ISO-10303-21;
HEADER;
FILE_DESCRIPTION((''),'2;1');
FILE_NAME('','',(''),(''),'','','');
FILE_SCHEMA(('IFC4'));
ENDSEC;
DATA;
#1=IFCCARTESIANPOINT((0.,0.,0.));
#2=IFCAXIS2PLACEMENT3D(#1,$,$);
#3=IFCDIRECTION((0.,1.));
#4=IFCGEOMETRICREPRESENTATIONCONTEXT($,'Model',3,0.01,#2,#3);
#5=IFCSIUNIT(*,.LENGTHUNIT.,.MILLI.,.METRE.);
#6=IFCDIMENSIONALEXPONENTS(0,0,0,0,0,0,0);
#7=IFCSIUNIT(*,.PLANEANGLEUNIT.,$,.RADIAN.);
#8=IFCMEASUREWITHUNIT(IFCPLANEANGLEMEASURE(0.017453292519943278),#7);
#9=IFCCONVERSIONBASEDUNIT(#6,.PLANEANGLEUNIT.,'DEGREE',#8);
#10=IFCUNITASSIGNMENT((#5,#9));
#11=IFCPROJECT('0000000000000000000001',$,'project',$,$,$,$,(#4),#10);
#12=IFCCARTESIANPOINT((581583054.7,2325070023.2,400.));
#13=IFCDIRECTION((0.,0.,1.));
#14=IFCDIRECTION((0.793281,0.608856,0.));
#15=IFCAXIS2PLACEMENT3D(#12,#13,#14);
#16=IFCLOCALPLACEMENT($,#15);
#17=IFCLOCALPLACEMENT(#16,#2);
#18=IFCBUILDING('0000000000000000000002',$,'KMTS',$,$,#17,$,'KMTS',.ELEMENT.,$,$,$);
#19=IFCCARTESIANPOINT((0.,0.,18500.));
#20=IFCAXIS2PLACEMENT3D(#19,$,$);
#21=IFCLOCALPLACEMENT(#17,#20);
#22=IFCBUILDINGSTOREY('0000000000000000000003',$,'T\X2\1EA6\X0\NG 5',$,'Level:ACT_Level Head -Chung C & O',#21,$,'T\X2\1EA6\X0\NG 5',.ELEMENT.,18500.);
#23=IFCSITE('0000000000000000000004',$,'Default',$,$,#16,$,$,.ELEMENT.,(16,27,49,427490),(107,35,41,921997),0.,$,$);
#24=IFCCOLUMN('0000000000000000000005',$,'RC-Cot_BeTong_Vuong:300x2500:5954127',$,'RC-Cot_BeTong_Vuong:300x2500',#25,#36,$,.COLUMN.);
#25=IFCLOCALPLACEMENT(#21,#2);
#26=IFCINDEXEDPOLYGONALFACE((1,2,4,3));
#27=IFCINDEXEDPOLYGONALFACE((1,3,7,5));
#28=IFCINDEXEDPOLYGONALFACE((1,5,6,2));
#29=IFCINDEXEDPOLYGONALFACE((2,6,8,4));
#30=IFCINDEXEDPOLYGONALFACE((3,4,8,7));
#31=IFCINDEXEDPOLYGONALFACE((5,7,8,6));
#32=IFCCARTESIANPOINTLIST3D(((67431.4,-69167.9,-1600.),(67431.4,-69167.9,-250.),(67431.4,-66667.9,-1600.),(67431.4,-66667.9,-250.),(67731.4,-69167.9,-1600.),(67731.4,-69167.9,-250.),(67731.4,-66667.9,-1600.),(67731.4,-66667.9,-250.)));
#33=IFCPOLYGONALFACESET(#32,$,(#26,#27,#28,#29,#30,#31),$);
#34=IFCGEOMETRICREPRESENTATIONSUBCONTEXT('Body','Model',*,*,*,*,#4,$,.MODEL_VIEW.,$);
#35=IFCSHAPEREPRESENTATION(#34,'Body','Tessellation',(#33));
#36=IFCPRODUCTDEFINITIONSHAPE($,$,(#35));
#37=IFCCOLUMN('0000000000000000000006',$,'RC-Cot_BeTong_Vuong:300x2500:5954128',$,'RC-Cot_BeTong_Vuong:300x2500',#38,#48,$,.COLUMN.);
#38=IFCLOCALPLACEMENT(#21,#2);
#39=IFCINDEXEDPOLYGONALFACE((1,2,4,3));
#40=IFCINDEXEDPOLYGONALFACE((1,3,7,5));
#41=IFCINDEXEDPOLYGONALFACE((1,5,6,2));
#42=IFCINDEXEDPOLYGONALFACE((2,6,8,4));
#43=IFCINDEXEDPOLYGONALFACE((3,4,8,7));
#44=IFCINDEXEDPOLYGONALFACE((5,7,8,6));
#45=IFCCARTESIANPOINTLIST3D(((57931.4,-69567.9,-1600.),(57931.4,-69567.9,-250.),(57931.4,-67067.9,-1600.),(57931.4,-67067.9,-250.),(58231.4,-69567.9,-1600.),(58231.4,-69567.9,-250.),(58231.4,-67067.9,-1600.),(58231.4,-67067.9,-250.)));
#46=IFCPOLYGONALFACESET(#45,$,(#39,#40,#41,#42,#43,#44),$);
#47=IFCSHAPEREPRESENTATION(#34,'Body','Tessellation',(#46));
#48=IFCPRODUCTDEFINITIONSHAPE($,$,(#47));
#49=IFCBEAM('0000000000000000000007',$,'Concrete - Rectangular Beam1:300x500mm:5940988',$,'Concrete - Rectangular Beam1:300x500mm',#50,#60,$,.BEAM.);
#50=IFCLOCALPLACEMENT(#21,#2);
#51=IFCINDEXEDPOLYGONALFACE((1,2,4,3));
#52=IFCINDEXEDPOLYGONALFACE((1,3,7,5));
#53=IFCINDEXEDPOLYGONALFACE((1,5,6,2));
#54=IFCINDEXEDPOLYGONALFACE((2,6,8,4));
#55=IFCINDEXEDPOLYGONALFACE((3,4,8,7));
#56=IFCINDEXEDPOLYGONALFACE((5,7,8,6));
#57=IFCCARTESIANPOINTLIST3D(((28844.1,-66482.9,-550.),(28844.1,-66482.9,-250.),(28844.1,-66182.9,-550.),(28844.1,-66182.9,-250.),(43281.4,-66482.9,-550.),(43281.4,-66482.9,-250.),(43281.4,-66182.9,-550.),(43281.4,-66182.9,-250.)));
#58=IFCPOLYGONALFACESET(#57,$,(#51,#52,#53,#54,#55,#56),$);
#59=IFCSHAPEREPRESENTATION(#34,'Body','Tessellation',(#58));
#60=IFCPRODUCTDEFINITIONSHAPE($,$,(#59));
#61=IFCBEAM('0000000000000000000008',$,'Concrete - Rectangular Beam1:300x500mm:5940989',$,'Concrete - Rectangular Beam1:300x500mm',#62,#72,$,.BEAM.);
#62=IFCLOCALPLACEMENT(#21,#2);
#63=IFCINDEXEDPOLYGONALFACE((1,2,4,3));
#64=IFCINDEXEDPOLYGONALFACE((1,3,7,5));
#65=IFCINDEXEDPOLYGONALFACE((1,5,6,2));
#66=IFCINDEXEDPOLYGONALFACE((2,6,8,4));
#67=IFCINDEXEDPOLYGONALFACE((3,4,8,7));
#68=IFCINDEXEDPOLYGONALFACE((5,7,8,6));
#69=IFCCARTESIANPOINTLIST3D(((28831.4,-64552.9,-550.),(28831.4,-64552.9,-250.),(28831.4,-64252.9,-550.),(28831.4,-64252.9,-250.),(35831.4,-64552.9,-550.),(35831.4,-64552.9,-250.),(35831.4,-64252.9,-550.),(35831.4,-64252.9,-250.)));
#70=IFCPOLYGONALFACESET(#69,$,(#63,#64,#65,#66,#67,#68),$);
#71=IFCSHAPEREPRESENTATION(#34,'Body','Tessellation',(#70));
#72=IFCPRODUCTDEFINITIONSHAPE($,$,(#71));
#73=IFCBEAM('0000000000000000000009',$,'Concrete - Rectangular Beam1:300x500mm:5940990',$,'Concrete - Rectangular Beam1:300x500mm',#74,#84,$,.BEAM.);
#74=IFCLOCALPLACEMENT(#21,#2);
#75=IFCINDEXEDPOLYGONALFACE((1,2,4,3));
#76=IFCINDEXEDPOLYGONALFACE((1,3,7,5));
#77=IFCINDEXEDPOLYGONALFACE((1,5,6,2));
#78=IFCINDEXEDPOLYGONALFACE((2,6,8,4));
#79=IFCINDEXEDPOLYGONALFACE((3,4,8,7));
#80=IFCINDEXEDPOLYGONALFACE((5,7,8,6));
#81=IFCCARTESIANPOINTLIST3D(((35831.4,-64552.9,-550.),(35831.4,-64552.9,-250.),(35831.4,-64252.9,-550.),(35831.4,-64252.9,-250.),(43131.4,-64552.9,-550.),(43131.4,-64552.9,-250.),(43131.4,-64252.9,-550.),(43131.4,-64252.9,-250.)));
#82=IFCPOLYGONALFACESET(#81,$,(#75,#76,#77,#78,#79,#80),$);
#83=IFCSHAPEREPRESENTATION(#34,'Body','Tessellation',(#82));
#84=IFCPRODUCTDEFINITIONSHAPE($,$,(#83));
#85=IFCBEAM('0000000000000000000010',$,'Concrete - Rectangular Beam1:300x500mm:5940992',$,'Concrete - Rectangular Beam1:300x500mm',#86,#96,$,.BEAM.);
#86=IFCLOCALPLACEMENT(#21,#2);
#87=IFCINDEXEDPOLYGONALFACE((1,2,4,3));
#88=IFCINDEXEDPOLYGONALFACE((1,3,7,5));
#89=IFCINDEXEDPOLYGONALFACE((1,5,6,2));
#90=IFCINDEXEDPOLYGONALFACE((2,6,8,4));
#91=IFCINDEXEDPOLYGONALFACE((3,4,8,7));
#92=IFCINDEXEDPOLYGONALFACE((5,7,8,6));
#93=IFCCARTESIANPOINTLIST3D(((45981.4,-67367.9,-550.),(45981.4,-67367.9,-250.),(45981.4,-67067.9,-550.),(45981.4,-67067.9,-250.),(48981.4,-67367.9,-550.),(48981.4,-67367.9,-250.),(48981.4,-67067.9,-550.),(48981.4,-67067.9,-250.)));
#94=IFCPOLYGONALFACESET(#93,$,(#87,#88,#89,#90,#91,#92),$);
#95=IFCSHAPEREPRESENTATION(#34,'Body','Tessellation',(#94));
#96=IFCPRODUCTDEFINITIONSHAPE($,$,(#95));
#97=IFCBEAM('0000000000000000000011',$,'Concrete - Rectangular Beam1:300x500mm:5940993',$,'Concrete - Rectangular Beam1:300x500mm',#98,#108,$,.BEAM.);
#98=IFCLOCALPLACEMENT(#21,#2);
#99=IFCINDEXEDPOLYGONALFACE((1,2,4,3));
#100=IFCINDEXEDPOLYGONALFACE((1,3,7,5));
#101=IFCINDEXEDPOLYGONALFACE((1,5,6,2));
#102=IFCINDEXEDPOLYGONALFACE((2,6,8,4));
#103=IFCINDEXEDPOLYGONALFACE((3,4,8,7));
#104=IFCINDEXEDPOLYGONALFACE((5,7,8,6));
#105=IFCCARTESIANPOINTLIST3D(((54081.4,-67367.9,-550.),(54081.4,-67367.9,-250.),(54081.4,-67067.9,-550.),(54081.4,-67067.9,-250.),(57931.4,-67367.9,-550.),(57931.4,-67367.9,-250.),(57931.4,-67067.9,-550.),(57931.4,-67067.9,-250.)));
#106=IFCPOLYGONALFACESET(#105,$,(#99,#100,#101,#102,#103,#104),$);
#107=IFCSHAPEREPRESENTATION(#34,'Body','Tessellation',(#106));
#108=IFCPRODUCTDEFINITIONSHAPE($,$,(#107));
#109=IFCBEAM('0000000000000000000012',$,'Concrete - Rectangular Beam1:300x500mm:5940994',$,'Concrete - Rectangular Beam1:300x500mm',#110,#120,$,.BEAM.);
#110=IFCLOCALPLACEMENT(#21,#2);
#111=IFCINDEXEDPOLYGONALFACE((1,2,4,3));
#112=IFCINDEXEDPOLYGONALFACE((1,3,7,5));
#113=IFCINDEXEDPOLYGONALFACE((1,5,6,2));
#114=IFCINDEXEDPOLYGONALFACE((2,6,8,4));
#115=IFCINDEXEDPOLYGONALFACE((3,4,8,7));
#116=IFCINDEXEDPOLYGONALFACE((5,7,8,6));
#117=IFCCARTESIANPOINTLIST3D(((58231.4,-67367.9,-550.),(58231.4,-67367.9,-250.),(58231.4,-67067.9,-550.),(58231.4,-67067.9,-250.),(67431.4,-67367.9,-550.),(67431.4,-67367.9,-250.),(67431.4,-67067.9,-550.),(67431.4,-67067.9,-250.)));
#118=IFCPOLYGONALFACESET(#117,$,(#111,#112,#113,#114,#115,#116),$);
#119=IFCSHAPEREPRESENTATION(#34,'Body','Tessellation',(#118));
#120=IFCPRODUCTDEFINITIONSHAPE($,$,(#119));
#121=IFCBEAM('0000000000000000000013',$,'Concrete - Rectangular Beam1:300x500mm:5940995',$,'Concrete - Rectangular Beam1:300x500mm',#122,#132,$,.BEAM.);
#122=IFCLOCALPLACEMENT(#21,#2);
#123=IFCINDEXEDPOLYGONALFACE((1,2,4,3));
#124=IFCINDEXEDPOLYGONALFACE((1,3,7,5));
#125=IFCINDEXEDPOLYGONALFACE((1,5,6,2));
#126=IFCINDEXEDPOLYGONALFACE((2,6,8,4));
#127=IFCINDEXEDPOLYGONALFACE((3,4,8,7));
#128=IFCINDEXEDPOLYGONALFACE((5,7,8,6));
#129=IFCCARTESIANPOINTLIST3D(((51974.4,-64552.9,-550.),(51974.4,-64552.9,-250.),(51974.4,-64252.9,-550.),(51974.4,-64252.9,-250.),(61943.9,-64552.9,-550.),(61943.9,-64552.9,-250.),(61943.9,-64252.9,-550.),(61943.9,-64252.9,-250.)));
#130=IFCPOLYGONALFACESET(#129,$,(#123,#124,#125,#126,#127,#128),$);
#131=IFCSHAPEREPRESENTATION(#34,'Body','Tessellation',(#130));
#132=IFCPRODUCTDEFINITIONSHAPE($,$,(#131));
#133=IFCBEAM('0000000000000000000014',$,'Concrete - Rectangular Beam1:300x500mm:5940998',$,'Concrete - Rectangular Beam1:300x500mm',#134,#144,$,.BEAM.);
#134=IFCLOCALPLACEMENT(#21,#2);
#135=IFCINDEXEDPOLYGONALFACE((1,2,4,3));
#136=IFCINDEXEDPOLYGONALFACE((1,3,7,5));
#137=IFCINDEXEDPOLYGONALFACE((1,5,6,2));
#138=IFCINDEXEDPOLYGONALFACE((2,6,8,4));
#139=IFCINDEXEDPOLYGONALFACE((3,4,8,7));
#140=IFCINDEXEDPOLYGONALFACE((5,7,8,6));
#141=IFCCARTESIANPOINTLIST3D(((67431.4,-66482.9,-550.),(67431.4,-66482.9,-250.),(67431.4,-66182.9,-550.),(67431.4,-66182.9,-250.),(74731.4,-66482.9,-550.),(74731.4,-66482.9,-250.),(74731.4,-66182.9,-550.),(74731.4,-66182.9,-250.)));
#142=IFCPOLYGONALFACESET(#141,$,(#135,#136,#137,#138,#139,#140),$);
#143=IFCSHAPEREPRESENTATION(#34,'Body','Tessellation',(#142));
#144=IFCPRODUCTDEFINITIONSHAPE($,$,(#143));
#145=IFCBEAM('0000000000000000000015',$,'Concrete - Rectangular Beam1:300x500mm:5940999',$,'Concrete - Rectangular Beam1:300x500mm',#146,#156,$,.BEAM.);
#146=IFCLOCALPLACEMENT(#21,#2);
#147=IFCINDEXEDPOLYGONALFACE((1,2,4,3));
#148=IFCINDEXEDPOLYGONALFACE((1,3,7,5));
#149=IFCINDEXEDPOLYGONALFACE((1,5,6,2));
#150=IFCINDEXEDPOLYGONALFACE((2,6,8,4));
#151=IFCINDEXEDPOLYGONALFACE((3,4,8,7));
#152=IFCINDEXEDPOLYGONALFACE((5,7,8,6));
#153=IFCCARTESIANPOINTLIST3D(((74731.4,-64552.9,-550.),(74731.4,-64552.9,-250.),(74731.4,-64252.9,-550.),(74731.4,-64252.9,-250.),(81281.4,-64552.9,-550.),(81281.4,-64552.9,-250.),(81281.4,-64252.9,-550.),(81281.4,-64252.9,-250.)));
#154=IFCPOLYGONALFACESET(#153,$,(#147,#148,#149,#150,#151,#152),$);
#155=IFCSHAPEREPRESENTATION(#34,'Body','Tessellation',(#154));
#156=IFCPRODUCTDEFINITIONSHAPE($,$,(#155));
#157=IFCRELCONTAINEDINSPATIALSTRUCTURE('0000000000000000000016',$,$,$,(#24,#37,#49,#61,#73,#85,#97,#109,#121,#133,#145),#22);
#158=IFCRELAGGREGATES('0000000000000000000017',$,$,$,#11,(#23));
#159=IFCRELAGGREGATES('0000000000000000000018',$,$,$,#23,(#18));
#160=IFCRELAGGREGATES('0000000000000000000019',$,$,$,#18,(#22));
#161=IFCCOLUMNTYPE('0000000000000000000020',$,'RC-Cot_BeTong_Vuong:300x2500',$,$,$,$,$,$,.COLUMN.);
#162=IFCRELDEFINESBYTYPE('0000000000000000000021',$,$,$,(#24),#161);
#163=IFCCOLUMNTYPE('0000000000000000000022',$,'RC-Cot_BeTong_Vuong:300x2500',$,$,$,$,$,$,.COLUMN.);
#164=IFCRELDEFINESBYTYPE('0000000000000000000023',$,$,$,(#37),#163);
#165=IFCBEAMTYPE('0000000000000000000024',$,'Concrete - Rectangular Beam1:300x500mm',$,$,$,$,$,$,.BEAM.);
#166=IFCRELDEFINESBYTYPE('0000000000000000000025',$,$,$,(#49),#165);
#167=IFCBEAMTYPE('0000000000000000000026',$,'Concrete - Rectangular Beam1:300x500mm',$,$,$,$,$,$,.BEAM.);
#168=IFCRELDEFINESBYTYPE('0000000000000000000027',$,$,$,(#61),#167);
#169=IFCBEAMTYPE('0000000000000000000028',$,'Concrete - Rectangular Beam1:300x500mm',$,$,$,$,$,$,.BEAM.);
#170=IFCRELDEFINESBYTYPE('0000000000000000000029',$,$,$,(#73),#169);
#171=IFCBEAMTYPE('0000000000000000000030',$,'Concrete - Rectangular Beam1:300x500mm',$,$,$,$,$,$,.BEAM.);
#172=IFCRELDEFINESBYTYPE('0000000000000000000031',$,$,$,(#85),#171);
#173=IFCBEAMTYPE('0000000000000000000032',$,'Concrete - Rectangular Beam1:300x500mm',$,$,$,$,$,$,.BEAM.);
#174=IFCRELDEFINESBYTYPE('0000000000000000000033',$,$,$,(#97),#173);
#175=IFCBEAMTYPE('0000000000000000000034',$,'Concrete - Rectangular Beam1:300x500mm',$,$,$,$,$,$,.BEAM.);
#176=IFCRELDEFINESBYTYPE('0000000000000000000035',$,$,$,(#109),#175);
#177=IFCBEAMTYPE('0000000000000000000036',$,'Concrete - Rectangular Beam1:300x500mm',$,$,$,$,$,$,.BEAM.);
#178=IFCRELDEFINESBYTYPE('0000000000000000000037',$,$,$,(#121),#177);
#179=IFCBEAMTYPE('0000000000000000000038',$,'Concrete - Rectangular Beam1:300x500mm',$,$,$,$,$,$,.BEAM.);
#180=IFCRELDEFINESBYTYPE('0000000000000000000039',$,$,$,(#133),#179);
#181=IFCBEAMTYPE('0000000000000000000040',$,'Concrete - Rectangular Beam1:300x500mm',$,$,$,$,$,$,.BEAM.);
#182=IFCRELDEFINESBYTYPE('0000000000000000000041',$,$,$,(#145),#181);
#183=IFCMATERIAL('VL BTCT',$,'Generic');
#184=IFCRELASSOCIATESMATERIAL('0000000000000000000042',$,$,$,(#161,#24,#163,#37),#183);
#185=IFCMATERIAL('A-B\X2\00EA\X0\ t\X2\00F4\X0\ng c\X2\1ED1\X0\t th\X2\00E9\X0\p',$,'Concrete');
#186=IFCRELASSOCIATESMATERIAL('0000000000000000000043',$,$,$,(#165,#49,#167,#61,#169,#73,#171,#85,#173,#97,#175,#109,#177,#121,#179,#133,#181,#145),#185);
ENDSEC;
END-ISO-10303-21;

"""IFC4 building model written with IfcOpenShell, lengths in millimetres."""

from ifc_helpers import new_model, entity, si_unit, converted_unit, direction, frame, origin, place, context, subcontext, project, spatial, indexed_curve, outline, extrude, source, transform, mapped, material, type_object, type_shapes, element, save


model = new_model("IFC4")

# Units and contexts
model_context = context("Model", 3, precision=0.01, world=origin(), true_north=direction((0.0, 1.0)))
body_context = subcontext(model_context, "Body", "Model", "MODEL_VIEW")
ifc_project = project(units=[si_unit("LENGTHUNIT", "METRE", prefix="MILLI"), converted_unit("PLANEANGLEUNIT", "DEGREE", entity("IfcPlaneAngleMeasure", 0.017453292519943278), si_unit("PLANEANGLEUNIT", "RADIAN"), dimensions=[0, 0, 0, 0, 0, 0, 0])], contexts=[model_context])

# Site, building, storey
site_placement = place(None, frame((581583054.7, 2325070023.2, 400.0), z_axis=(0.0, 0.0, 1.0), x_axis=(0.793281, 0.608856, 0.0)))
site = spatial("IfcSite", under=ifc_project, at=site_placement, Name="Default", CompositionType="ELEMENT", RefLatitude=(16, 27, 49, 427490), RefLongitude=(107, 35, 41, 921997), RefElevation=0.0)
building_placement = place(site_placement, origin())
building = spatial("IfcBuilding", under=site, at=building_placement, Name="KMTS", LongName="KMTS", CompositionType="ELEMENT")
storey_placement = place(building_placement, frame((0.0, 0.0, 18500.0)))
storey = spatial("IfcBuildingStorey", under=building, at=storey_placement, Name="TẦNG 5", ObjectType="Level:ACT_Level Head -Chung C & O", LongName="TẦNG 5", CompositionType="ELEMENT", Elevation=18500.0)

# Columns
ifc_material_1 = material(Name="VL BTCT", Category="Generic")
column_type_1 = type_object("IfcColumnType", Name="RC-Cot_BeTong_Vuong:300x2500", PredefinedType="COLUMN", material=ifc_material_1)
shared_shape_1 = source(origin(), body_context, "Body", "SweptSolid", [
    extrude(outline(indexed_curve([(-675.0, -1250.0), (675.0, -1250.0), (675.0, 1250.0), (-675.0, 1250.0), (-675.0, -1250.0)], self_intersect=False)), frame((67431.4, -67917.9, 17575.0), z_axis=(1.0, 0.0, 0.0), x_axis=(0.0, 0.0, 1.0)), (0.0, 0.0, 1.0), 300.0),
])
type_shapes(column_type_1, [shared_shape_1])
column_1_placement = place(storey_placement, frame((0.0, 0.0, -18500.0)))
element("IfcColumn", 1, at=column_1_placement, inside=storey, type_object=column_type_1, material=ifc_material_1, Name="RC-Cot_BeTong_Vuong:300x2500:5954127", ObjectType="RC-Cot_BeTong_Vuong:300x2500", PredefinedType="COLUMN", context=body_context, shape_type="MappedRepresentation", body=[
    mapped(shared_shape_1, transform((0.0, 0.0, 0.0), scale=1.0)),
])
column_type_2 = type_object("IfcColumnType", Name="RC-Cot_BeTong_Vuong:300x2500", PredefinedType="COLUMN", material=ifc_material_1)
shared_shape_2 = source(origin(), body_context, "Body", "SweptSolid", [
    extrude(outline(indexed_curve([(-675.0, -1250.0), (675.0, -1250.0), (675.0, 1250.0), (-675.0, 1250.0), (-675.0, -1250.0)], self_intersect=False)), frame((57931.4, -68317.9, 17575.0), z_axis=(1.0, 0.0, 0.0), x_axis=(0.0, 0.0, 1.0)), (0.0, 0.0, 1.0), 300.0),
])
type_shapes(column_type_2, [shared_shape_2])
column_2_placement = place(storey_placement, frame((0.0, 0.0, -18500.0)))
element("IfcColumn", 2, at=column_2_placement, inside=storey, type_object=column_type_2, material=ifc_material_1, Name="RC-Cot_BeTong_Vuong:300x2500:5954128", ObjectType="RC-Cot_BeTong_Vuong:300x2500", PredefinedType="COLUMN", context=body_context, shape_type="MappedRepresentation", body=[
    mapped(shared_shape_2, transform((0.0, 0.0, 0.0), scale=1.0)),
])

# Beams
ifc_material_2 = material(Name="A-Bê tông cốt thép", Category="Concrete")
beam_type_1 = type_object("IfcBeamType", Name="Concrete - Rectangular Beam1:300x500mm", PredefinedType="BEAM", material=ifc_material_2)
shared_shape_3 = source(origin(), body_context, "Body", "SweptSolid", [
    extrude(outline(indexed_curve([(-150.0, -150.0), (150.0, -150.0), (150.0, 150.0), (-150.0, 150.0), (-150.0, -150.0)], self_intersect=False)), frame((43281.4, -66332.9, 18100.0), z_axis=(-1.0, 0.0, 0.0), x_axis=(0.0, 0.0, -1.0)), (0.0, 0.0, 1.0), 14437.3),
])
type_shapes(beam_type_1, [shared_shape_3])
beam_1_placement = place(storey_placement, frame((0.0, 0.0, -18500.0)))
element("IfcBeam", 3, at=beam_1_placement, inside=storey, type_object=beam_type_1, material=ifc_material_2, Name="Concrete - Rectangular Beam1:300x500mm:5940988", ObjectType="Concrete - Rectangular Beam1:300x500mm", PredefinedType="BEAM", context=body_context, shape_type="MappedRepresentation", body=[
    mapped(shared_shape_3, transform((0.0, 0.0, 0.0), scale=1.0)),
])
beam_type_2 = type_object("IfcBeamType", Name="Concrete - Rectangular Beam1:300x500mm", PredefinedType="BEAM", material=ifc_material_2)
shared_shape_4 = source(origin(), body_context, "Body", "SweptSolid", [
    extrude(outline(indexed_curve([(-150.0, -150.0), (150.0, -150.0), (150.0, 150.0), (-150.0, 150.0), (-150.0, -150.0)], self_intersect=False)), frame((35831.4, -64402.9, 18100.0), z_axis=(-1.0, 0.0, 0.0), x_axis=(0.0, 0.0, -1.0)), (0.0, 0.0, 1.0), 7000.0),
])
type_shapes(beam_type_2, [shared_shape_4])
beam_2_placement = place(storey_placement, frame((0.0, 0.0, -18500.0)))
element("IfcBeam", 4, at=beam_2_placement, inside=storey, type_object=beam_type_2, material=ifc_material_2, Name="Concrete - Rectangular Beam1:300x500mm:5940989", ObjectType="Concrete - Rectangular Beam1:300x500mm", PredefinedType="BEAM", context=body_context, shape_type="MappedRepresentation", body=[
    mapped(shared_shape_4, transform((0.0, 0.0, 0.0), scale=1.0)),
])
beam_type_3 = type_object("IfcBeamType", Name="Concrete - Rectangular Beam1:300x500mm", PredefinedType="BEAM", material=ifc_material_2)
shared_shape_5 = source(origin(), body_context, "Body", "SweptSolid", [
    extrude(outline(indexed_curve([(-150.0, -150.0), (150.0, -150.0), (150.0, 150.0), (-150.0, 150.0), (-150.0, -150.0)], self_intersect=False)), frame((43131.4, -64402.9, 18100.0), z_axis=(-1.0, 0.0, 0.0), x_axis=(0.0, 0.0, -1.0)), (0.0, 0.0, 1.0), 7300.0),
])
type_shapes(beam_type_3, [shared_shape_5])
beam_3_placement = place(storey_placement, frame((0.0, 0.0, -18500.0)))
element("IfcBeam", 5, at=beam_3_placement, inside=storey, type_object=beam_type_3, material=ifc_material_2, Name="Concrete - Rectangular Beam1:300x500mm:5940990", ObjectType="Concrete - Rectangular Beam1:300x500mm", PredefinedType="BEAM", context=body_context, shape_type="MappedRepresentation", body=[
    mapped(shared_shape_5, transform((0.0, 0.0, 0.0), scale=1.0)),
])
beam_type_4 = type_object("IfcBeamType", Name="Concrete - Rectangular Beam1:300x500mm", PredefinedType="BEAM", material=ifc_material_2)
shared_shape_6 = source(origin(), body_context, "Body", "SweptSolid", [
    extrude(outline(indexed_curve([(-150.0, -150.0), (150.0, -150.0), (150.0, 150.0), (-150.0, 150.0), (-150.0, -150.0)], self_intersect=False)), frame((45981.4, -67217.9, 18100.0), z_axis=(1.0, 0.0, 0.0), x_axis=(0.0, 0.0, -1.0)), (0.0, 0.0, 1.0), 3000.0),
])
type_shapes(beam_type_4, [shared_shape_6])
beam_4_placement = place(storey_placement, frame((0.0, 0.0, -18500.0)))
element("IfcBeam", 6, at=beam_4_placement, inside=storey, type_object=beam_type_4, material=ifc_material_2, Name="Concrete - Rectangular Beam1:300x500mm:5940992", ObjectType="Concrete - Rectangular Beam1:300x500mm", PredefinedType="BEAM", context=body_context, shape_type="MappedRepresentation", body=[
    mapped(shared_shape_6, transform((0.0, 0.0, 0.0), scale=1.0)),
])
beam_type_5 = type_object("IfcBeamType", Name="Concrete - Rectangular Beam1:300x500mm", PredefinedType="BEAM", material=ifc_material_2)
shared_shape_7 = source(origin(), body_context, "Body", "SweptSolid", [
    extrude(outline(indexed_curve([(-150.0, -150.0), (150.0, -150.0), (150.0, 150.0), (-150.0, 150.0), (-150.0, -150.0)], self_intersect=False)), frame((57931.4, -67217.9, 18100.0), z_axis=(-1.0, 0.0, 0.0), x_axis=(0.0, 0.0, -1.0)), (0.0, 0.0, 1.0), 3850.0),
])
type_shapes(beam_type_5, [shared_shape_7])
beam_5_placement = place(storey_placement, frame((0.0, 0.0, -18500.0)))
element("IfcBeam", 7, at=beam_5_placement, inside=storey, type_object=beam_type_5, material=ifc_material_2, Name="Concrete - Rectangular Beam1:300x500mm:5940993", ObjectType="Concrete - Rectangular Beam1:300x500mm", PredefinedType="BEAM", context=body_context, shape_type="MappedRepresentation", body=[
    mapped(shared_shape_7, transform((0.0, 0.0, 0.0), scale=1.0)),
])
beam_type_6 = type_object("IfcBeamType", Name="Concrete - Rectangular Beam1:300x500mm", PredefinedType="BEAM", material=ifc_material_2)
shared_shape_8 = source(origin(), body_context, "Body", "SweptSolid", [
    extrude(outline(indexed_curve([(-150.0, -150.0), (150.0, -150.0), (150.0, 150.0), (-150.0, 150.0), (-150.0, -150.0)], self_intersect=False)), frame((58231.4, -67217.9, 18100.0), z_axis=(1.0, 0.0, 0.0), x_axis=(0.0, 0.0, -1.0)), (0.0, 0.0, 1.0), 9200.0),
])
type_shapes(beam_type_6, [shared_shape_8])
beam_6_placement = place(storey_placement, frame((0.0, 0.0, -18500.0)))
element("IfcBeam", 8, at=beam_6_placement, inside=storey, type_object=beam_type_6, material=ifc_material_2, Name="Concrete - Rectangular Beam1:300x500mm:5940994", ObjectType="Concrete - Rectangular Beam1:300x500mm", PredefinedType="BEAM", context=body_context, shape_type="MappedRepresentation", body=[
    mapped(shared_shape_8, transform((0.0, 0.0, 0.0), scale=1.0)),
])
beam_type_7 = type_object("IfcBeamType", Name="Concrete - Rectangular Beam1:300x500mm", PredefinedType="BEAM", material=ifc_material_2)
shared_shape_9 = source(origin(), body_context, "Body", "SweptSolid", [
    extrude(outline(indexed_curve([(-150.0, -150.0), (150.0, -150.0), (150.0, 150.0), (-150.0, 150.0), (-150.0, -150.0)], self_intersect=False)), frame((51974.4, -64402.9, 18100.0), z_axis=(1.0, 0.0, 0.0), x_axis=(0.0, 0.0, -1.0)), (0.0, 0.0, 1.0), 9969.5),
])
type_shapes(beam_type_7, [shared_shape_9])
beam_7_placement = place(storey_placement, frame((0.0, 0.0, -18500.0)))
element("IfcBeam", 9, at=beam_7_placement, inside=storey, type_object=beam_type_7, material=ifc_material_2, Name="Concrete - Rectangular Beam1:300x500mm:5940995", ObjectType="Concrete - Rectangular Beam1:300x500mm", PredefinedType="BEAM", context=body_context, shape_type="MappedRepresentation", body=[
    mapped(shared_shape_9, transform((0.0, 0.0, 0.0), scale=1.0)),
])
beam_type_8 = type_object("IfcBeamType", Name="Concrete - Rectangular Beam1:300x500mm", PredefinedType="BEAM", material=ifc_material_2)
shared_shape_10 = source(origin(), body_context, "Body", "SweptSolid", [
    extrude(outline(indexed_curve([(-150.0, -150.0), (150.0, -150.0), (150.0, 150.0), (-150.0, 150.0), (-150.0, -150.0)], self_intersect=False)), frame((74731.4, -66332.9, 18100.0), z_axis=(-1.0, 0.0, 0.0), x_axis=(0.0, 0.0, -1.0)), (0.0, 0.0, 1.0), 7300.0),
])
type_shapes(beam_type_8, [shared_shape_10])
beam_8_placement = place(storey_placement, frame((0.0, 0.0, -18500.0)))
element("IfcBeam", 10, at=beam_8_placement, inside=storey, type_object=beam_type_8, material=ifc_material_2, Name="Concrete - Rectangular Beam1:300x500mm:5940998", ObjectType="Concrete - Rectangular Beam1:300x500mm", PredefinedType="BEAM", context=body_context, shape_type="MappedRepresentation", body=[
    mapped(shared_shape_10, transform((0.0, 0.0, 0.0), scale=1.0)),
])
beam_type_9 = type_object("IfcBeamType", Name="Concrete - Rectangular Beam1:300x500mm", PredefinedType="BEAM", material=ifc_material_2)
shared_shape_11 = source(origin(), body_context, "Body", "SweptSolid", [
    extrude(outline(indexed_curve([(-150.0, -150.0), (150.0, -150.0), (150.0, 150.0), (-150.0, 150.0), (-150.0, -150.0)], self_intersect=False)), frame((81281.4, -64402.9, 18100.0), z_axis=(-1.0, 0.0, 0.0), x_axis=(0.0, 0.0, -1.0)), (0.0, 0.0, 1.0), 6550.0),
])
type_shapes(beam_type_9, [shared_shape_11])
beam_9_placement = place(storey_placement, frame((0.0, 0.0, -18500.0)))
element("IfcBeam", 11, at=beam_9_placement, inside=storey, type_object=beam_type_9, material=ifc_material_2, Name="Concrete - Rectangular Beam1:300x500mm:5940999", ObjectType="Concrete - Rectangular Beam1:300x500mm", PredefinedType="BEAM", context=body_context, shape_type="MappedRepresentation", body=[
    mapped(shared_shape_11, transform((0.0, 0.0, 0.0), scale=1.0)),
])

save(model, "model.ifc")
